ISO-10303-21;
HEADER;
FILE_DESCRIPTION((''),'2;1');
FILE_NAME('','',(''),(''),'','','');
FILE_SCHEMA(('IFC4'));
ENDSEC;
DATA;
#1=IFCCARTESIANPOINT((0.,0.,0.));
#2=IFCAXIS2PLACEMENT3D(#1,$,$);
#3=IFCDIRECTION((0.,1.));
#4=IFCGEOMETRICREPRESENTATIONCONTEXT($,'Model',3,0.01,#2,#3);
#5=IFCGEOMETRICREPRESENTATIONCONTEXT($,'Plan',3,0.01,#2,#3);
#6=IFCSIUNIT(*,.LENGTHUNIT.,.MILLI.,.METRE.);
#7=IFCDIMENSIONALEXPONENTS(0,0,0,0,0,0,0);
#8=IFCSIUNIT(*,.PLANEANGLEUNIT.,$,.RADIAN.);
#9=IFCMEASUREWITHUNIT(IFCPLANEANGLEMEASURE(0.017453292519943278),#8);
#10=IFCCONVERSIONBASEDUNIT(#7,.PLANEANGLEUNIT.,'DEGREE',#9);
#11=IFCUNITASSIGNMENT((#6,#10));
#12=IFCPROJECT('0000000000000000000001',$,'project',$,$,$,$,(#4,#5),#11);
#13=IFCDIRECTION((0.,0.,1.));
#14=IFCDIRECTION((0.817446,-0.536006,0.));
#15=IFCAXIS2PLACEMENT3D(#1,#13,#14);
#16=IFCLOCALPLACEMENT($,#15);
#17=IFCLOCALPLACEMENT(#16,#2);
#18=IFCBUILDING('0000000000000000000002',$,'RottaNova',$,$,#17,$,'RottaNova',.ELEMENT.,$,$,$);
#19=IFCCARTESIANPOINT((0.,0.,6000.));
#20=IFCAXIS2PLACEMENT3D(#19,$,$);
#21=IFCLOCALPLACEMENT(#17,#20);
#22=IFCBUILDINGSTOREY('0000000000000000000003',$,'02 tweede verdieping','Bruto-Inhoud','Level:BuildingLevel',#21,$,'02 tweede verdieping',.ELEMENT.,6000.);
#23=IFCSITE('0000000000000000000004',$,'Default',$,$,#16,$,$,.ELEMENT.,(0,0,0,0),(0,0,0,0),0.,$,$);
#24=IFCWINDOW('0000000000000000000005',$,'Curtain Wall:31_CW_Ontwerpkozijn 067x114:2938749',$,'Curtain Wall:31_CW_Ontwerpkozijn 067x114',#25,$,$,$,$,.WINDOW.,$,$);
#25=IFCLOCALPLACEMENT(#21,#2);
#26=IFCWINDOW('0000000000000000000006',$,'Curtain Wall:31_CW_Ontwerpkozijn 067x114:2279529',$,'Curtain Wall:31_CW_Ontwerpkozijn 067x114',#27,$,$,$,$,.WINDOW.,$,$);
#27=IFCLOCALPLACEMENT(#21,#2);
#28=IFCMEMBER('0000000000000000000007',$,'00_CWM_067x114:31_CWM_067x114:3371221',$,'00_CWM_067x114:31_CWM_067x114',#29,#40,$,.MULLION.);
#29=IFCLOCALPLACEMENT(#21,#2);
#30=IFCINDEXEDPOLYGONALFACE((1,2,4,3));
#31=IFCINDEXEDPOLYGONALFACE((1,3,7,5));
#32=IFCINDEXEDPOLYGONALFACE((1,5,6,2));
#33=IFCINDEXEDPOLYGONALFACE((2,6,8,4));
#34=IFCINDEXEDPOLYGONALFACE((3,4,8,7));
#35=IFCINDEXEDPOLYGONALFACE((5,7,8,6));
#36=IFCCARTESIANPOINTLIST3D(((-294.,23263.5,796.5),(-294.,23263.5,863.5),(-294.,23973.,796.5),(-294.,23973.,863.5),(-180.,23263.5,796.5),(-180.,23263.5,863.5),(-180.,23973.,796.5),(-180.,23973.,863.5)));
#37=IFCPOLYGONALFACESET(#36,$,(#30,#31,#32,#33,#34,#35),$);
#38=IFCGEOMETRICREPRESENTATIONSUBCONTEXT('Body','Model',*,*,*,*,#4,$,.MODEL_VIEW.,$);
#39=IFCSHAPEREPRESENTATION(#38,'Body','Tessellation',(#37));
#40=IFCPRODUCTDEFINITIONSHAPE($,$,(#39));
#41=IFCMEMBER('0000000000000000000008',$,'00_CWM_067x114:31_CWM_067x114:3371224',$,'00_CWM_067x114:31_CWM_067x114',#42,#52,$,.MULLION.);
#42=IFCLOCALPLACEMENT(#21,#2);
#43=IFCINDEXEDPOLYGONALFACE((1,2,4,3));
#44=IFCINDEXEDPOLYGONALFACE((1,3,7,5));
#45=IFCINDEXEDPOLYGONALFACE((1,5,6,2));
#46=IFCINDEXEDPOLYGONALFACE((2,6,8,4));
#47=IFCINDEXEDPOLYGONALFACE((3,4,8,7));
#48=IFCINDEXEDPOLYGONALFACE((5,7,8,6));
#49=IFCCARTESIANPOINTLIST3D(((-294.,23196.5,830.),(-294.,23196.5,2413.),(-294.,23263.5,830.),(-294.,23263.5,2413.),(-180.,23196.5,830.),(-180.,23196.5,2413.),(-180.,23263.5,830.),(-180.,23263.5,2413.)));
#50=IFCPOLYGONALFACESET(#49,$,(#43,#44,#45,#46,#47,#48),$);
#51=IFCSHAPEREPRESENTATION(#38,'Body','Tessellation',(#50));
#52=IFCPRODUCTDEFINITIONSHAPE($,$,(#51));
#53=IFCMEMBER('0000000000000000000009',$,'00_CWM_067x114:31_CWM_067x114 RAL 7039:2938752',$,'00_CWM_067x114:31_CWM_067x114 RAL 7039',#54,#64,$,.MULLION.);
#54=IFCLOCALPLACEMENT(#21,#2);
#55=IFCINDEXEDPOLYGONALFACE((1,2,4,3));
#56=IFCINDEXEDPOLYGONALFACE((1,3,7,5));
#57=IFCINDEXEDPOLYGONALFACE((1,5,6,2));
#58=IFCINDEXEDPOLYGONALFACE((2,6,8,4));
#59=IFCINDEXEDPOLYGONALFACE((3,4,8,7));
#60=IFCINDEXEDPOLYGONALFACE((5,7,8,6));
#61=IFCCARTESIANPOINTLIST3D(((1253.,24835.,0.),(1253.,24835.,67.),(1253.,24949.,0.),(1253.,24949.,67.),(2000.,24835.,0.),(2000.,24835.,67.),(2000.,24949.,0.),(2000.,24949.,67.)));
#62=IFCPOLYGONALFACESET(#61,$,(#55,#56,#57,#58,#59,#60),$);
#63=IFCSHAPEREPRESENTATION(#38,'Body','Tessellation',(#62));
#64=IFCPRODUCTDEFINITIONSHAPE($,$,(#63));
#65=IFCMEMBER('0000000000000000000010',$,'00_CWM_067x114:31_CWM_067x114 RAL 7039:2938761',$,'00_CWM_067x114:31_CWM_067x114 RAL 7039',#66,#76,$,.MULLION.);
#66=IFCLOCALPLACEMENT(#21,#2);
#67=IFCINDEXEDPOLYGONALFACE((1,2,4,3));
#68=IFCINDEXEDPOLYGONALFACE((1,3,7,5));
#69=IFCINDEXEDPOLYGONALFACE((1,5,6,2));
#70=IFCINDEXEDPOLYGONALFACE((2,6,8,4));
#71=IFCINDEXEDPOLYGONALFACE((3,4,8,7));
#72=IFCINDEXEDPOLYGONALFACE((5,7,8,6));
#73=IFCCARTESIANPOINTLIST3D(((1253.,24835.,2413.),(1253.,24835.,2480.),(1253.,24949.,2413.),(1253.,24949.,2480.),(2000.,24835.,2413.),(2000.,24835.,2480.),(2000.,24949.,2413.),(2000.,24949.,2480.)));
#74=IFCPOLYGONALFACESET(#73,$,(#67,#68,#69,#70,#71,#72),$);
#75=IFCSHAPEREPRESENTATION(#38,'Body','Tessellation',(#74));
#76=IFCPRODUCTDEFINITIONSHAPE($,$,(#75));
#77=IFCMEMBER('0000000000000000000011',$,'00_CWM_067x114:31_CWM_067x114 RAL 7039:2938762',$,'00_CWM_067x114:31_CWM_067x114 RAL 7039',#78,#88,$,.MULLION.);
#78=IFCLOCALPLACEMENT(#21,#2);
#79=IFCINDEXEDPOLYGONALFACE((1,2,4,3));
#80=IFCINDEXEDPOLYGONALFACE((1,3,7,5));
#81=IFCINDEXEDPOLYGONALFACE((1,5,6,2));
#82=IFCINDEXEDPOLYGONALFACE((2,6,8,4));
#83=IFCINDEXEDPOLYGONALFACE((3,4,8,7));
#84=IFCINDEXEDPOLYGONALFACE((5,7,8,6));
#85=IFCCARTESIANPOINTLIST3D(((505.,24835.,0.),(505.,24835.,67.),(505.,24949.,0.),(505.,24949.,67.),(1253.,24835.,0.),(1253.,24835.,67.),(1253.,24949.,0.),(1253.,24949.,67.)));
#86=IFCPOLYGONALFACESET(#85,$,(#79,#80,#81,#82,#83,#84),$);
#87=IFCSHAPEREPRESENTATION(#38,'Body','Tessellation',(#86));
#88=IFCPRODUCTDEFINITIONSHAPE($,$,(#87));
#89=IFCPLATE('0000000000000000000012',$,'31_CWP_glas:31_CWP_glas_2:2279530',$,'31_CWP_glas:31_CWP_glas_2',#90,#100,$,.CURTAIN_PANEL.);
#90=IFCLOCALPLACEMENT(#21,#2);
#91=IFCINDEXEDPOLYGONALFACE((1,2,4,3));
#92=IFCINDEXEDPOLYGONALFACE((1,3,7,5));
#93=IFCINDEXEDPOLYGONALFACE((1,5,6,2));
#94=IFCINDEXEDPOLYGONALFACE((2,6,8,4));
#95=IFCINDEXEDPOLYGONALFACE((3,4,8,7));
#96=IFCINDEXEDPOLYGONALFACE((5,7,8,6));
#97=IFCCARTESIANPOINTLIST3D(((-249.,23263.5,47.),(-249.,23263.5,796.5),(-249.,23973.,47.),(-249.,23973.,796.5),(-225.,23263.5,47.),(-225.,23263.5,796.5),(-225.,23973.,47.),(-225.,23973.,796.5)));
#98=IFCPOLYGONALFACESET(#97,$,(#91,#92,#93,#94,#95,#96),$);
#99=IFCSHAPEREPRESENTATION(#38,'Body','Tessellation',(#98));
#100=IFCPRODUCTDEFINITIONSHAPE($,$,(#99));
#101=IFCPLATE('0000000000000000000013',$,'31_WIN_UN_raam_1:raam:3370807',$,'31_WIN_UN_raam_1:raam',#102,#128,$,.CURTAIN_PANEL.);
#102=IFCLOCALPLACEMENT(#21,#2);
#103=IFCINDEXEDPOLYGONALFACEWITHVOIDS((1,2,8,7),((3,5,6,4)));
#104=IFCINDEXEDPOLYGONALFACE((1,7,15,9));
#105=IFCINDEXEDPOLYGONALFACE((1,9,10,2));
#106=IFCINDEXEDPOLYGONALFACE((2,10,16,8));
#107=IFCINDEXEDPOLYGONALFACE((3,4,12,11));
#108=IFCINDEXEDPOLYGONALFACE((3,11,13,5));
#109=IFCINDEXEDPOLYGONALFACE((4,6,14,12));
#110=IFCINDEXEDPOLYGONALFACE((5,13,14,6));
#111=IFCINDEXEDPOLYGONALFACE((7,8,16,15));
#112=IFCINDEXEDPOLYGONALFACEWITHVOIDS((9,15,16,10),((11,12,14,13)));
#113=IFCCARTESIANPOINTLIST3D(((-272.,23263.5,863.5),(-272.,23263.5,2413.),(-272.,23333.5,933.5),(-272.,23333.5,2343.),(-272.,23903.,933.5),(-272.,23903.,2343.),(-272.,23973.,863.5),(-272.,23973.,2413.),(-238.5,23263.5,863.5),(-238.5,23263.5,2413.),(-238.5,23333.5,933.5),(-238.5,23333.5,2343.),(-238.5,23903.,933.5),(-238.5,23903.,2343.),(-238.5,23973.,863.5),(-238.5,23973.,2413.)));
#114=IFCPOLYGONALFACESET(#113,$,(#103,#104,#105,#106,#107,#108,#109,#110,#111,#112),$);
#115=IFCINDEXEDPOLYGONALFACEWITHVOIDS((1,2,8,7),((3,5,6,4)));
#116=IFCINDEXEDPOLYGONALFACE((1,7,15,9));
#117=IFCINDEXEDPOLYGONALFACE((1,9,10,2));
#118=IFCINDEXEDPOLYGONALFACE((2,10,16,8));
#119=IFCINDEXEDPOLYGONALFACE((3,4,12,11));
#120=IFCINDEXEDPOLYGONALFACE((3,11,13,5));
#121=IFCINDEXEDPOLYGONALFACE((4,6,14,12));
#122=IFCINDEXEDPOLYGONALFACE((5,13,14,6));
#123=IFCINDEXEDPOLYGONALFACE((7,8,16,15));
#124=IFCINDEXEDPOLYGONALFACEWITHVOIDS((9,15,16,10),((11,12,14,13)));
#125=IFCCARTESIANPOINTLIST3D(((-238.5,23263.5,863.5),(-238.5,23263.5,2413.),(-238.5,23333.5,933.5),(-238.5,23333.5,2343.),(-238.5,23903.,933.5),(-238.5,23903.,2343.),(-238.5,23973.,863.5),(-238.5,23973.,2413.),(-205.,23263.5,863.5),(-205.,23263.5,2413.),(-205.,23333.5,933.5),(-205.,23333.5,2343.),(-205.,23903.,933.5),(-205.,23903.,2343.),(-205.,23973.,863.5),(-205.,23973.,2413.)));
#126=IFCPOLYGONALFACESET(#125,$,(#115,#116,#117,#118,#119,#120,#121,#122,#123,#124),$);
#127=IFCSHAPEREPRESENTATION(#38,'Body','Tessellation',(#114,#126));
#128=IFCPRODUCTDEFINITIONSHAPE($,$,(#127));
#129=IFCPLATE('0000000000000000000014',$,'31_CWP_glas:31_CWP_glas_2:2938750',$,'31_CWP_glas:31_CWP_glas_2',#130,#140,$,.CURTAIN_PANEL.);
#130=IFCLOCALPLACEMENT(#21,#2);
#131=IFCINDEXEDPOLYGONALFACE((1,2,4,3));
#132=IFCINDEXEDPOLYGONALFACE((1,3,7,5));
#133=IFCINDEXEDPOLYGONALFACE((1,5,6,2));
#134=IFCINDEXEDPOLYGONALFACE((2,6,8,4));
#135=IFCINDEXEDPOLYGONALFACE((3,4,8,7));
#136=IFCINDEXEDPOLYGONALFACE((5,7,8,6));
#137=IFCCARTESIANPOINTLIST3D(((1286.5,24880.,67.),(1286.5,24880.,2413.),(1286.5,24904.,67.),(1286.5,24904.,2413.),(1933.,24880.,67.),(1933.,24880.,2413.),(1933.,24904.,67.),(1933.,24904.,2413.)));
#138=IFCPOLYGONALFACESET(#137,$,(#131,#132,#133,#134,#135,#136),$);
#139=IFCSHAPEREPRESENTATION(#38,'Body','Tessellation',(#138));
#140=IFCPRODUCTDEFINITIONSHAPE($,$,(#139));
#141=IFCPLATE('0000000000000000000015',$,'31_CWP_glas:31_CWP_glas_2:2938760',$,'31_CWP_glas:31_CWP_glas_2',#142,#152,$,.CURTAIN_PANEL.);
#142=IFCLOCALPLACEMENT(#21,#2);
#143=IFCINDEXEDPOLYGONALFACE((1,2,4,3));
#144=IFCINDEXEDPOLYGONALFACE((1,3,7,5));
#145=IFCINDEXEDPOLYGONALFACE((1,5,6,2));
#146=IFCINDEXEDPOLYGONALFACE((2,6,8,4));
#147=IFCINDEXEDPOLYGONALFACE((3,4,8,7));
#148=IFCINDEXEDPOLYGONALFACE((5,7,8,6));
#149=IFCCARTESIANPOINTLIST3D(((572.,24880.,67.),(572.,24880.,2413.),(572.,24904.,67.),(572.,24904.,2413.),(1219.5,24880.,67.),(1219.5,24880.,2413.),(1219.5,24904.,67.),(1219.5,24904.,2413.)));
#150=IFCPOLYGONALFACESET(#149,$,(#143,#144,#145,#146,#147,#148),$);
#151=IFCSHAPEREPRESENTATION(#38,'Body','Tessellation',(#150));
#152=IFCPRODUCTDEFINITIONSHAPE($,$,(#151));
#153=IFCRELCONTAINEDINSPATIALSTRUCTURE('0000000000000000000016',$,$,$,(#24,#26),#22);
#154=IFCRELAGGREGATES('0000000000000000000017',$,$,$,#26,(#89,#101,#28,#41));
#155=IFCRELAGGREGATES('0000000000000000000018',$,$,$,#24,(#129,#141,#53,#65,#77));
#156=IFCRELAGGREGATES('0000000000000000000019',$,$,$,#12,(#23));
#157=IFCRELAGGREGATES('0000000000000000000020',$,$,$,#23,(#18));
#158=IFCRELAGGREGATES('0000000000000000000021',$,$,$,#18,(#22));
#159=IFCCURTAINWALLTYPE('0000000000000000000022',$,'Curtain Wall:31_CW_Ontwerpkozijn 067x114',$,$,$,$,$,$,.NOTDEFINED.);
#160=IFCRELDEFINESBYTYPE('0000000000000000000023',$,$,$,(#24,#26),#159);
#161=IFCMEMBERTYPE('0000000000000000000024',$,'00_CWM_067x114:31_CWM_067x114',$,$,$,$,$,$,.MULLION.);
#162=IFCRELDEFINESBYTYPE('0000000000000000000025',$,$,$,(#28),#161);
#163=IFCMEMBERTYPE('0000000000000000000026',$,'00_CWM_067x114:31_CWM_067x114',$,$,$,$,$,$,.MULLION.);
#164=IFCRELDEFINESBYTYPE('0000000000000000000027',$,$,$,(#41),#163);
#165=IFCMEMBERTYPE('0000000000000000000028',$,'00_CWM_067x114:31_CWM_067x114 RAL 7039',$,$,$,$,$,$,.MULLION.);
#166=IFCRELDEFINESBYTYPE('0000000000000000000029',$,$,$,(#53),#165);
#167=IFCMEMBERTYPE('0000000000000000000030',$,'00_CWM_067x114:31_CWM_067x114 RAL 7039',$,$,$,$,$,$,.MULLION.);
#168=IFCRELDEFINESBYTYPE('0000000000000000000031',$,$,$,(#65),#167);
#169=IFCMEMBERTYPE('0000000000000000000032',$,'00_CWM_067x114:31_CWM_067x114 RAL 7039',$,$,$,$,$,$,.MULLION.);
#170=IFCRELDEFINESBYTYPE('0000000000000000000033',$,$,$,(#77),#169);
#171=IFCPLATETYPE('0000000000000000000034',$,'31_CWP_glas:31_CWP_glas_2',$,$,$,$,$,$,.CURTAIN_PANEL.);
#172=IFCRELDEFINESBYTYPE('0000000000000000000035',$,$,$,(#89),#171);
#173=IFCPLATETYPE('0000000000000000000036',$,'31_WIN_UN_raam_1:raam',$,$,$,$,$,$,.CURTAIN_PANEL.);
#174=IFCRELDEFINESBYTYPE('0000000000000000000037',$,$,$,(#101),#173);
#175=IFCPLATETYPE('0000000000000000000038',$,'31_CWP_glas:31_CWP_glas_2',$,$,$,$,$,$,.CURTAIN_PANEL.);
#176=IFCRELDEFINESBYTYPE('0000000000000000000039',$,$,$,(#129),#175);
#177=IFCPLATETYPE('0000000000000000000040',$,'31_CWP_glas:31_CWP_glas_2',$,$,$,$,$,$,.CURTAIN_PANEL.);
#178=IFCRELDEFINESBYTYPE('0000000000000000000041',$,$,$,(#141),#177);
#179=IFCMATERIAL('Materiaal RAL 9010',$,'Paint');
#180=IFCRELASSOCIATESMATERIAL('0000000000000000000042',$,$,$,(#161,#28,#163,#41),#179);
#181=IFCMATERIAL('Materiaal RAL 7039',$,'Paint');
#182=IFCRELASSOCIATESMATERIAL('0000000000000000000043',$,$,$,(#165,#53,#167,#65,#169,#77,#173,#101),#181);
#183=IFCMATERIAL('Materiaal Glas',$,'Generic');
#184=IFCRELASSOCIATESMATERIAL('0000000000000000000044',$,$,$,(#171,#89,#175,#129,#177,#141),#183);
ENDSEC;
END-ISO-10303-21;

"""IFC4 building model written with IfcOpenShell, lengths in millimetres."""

from ifc_helpers import new_model, entity, si_unit, converted_unit, direction, frame, origin, place, context, subcontext, project, spatial, indexed_curve, outline, extrude, source, transform, mapped, material, type_object, type_shapes, element, aggregate, save


model = new_model("IFC4")

# Units and contexts
model_context = context("Model", 3, precision=0.01, world=origin(), true_north=direction((0.0, 1.0)))
plan_context = context("Plan", 3, precision=0.01, world=origin(), true_north=direction((0.0, 1.0)))
body_context = subcontext(model_context, "Body", "Model", "MODEL_VIEW")
ifc_project = project(units=[si_unit("LENGTHUNIT", "METRE", prefix="MILLI"), converted_unit("PLANEANGLEUNIT", "DEGREE", entity("IfcPlaneAngleMeasure", 0.017453292519943278), si_unit("PLANEANGLEUNIT", "RADIAN"), dimensions=[0, 0, 0, 0, 0, 0, 0])], contexts=[model_context, plan_context])

# Site, building, storey
site_placement = place(None, frame((0.0, 0.0, 0.0), z_axis=(0.0, 0.0, 1.0), x_axis=(0.817446, -0.536006, 0.0)))
site = spatial("IfcSite", under=ifc_project, at=site_placement, Name="Default", CompositionType="ELEMENT", RefLatitude=(0, 0, 0, 0), RefLongitude=(0, 0, 0, 0), RefElevation=0.0)
building_placement = place(site_placement, origin())
building = spatial("IfcBuilding", under=site, at=building_placement, Name="RottaNova", LongName="RottaNova", CompositionType="ELEMENT")
storey_placement = place(building_placement, frame((0.0, 0.0, 6000.0)))
storey = spatial("IfcBuildingStorey", under=building, at=storey_placement, Name="02 tweede verdieping", Description="Bruto-Inhoud", ObjectType="Level:BuildingLevel", LongName="02 tweede verdieping", CompositionType="ELEMENT", Elevation=6000.0)

# Window
curtain_wall_type = type_object("IfcCurtainWallType", Name="Curtain Wall:31_CW_Ontwerpkozijn 067x114", PredefinedType="NOTDEFINED")
ifc_material_1 = material(Name="Materiaal RAL 7039", Category="Paint")
window_1_placement = place(storey_placement, frame((0.0, 0.0, -6000.0)))
window_1 = element("IfcWindow", 1, at=window_1_placement, inside=storey, type_object=curtain_wall_type, Name="Curtain Wall:31_CW_Ontwerpkozijn 067x114:2938749", ObjectType="Curtain Wall:31_CW_Ontwerpkozijn 067x114", PredefinedType="WINDOW")

# Window, members
window_2_placement = place(storey_placement, frame((0.0, 0.0, -6000.0)))
window_2 = element("IfcWindow", 2, at=window_2_placement, inside=storey, type_object=curtain_wall_type, Name="Curtain Wall:31_CW_Ontwerpkozijn 067x114:2279529", ObjectType="Curtain Wall:31_CW_Ontwerpkozijn 067x114", PredefinedType="WINDOW")
ifc_material_2 = material(Name="Materiaal RAL 9010", Category="Paint")
member_type_1 = type_object("IfcMemberType", Name="00_CWM_067x114:31_CWM_067x114", PredefinedType="MULLION", material=ifc_material_2)
shared_shape_1 = source(origin(), body_context, "Body", "SweptSolid", [
    extrude(outline(indexed_curve([(-33.5, -57.0), (33.5, -57.0), (33.5, 57.0), (-33.5, 57.0), (-33.5, -57.0)], self_intersect=False)), frame((0.0, 57.0, -709.5), z_axis=(0.0, 0.0, 1.0), x_axis=(-1.0, 0.0, 0.0)), (0.0, 0.0, 1.0), 709.5),
])
type_shapes(member_type_1, [shared_shape_1])
member_1_placement = place(window_2_placement, frame((-180.0, 23263.5, 6830.0), z_axis=(0.0, -1.0, 0.0), x_axis=(0.0, 0.0, 1.0)))
member_1 = element("IfcMember", 3, at=member_1_placement, type_object=member_type_1, material=ifc_material_2, Name="00_CWM_067x114:31_CWM_067x114:3371221", ObjectType="00_CWM_067x114:31_CWM_067x114", PredefinedType="MULLION", context=body_context, shape_type="MappedRepresentation", body=[
    mapped(shared_shape_1, transform((0.0, 0.0, 0.0), scale=1.0)),
])
member_type_2 = type_object("IfcMemberType", Name="00_CWM_067x114:31_CWM_067x114", PredefinedType="MULLION", material=ifc_material_2)
shared_shape_2 = source(origin(), body_context, "Body", "SweptSolid", [
    extrude(outline(indexed_curve([(-33.5, -57.0), (33.5, -57.0), (33.5, 57.0), (-33.5, 57.0), (-33.5, -57.0)], self_intersect=False)), frame((0.0, 57.0, -1583.0), z_axis=(0.0, 0.0, 1.0), x_axis=(-1.0, 0.0, 0.0)), (0.0, 0.0, 1.0), 1583.0),
])
type_shapes(member_type_2, [shared_shape_2])
member_2_placement = place(window_2_placement, frame((-180.0, 23230.0, 6830.0), z_axis=(0.0, 0.0, -1.0), x_axis=(0.0, -1.0, 0.0)))
member_2 = element("IfcMember", 4, at=member_2_placement, type_object=member_type_2, material=ifc_material_2, Name="00_CWM_067x114:31_CWM_067x114:3371224", ObjectType="00_CWM_067x114:31_CWM_067x114", PredefinedType="MULLION", context=body_context, shape_type="MappedRepresentation", body=[
    mapped(shared_shape_2, transform((0.0, 0.0, 0.0), scale=1.0)),
])

# Members
member_type_3 = type_object("IfcMemberType", Name="00_CWM_067x114:31_CWM_067x114 RAL 7039", PredefinedType="MULLION", material=ifc_material_1)
shared_shape_3 = source(origin(), body_context, "Body", "SweptSolid", [
    extrude(outline(indexed_curve([(-33.5, -57.0), (33.5, -57.0), (33.5, 57.0), (-33.5, 57.0), (-33.5, -57.0)], self_intersect=False)), frame((-33.5, 57.0, -747.0), z_axis=(0.0, 0.0, 1.0), x_axis=(-1.0, 0.0, 0.0)), (0.0, 0.0, 1.0), 747.0),
])
type_shapes(member_type_3, [shared_shape_3])
member_3_placement = place(window_1_placement, frame((2000.0, 24835.0, 6000.0), z_axis=(1.0, 0.0, 0.0), x_axis=(0.0, 0.0, -1.0)))
member_3 = element("IfcMember", 5, at=member_3_placement, type_object=member_type_3, material=ifc_material_1, Name="00_CWM_067x114:31_CWM_067x114 RAL 7039:2938752", ObjectType="00_CWM_067x114:31_CWM_067x114 RAL 7039", PredefinedType="MULLION", context=body_context, shape_type="MappedRepresentation", body=[
    mapped(shared_shape_3, transform((0.0, 0.0, 0.0), scale=1.0)),
])
member_type_4 = type_object("IfcMemberType", Name="00_CWM_067x114:31_CWM_067x114 RAL 7039", PredefinedType="MULLION", material=ifc_material_1)
shared_shape_4 = source(origin(), body_context, "Body", "SweptSolid", [
    extrude(outline(indexed_curve([(-33.5, -57.0), (33.5, -57.0), (33.5, 57.0), (-33.5, 57.0), (-33.5, -57.0)], self_intersect=False)), frame((-33.5, 57.0, -747.0), z_axis=(0.0, 0.0, 1.0), x_axis=(-1.0, 0.0, 0.0)), (0.0, 0.0, 1.0), 747.0),
])
type_shapes(member_type_4, [shared_shape_4])
member_4_placement = place(window_1_placement, frame((1253.0, 24835.0, 8480.0), z_axis=(-1.0, 0.0, 0.0), x_axis=(0.0, 0.0, 1.0)))
member_4 = element("IfcMember", 6, at=member_4_placement, type_object=member_type_4, material=ifc_material_1, Name="00_CWM_067x114:31_CWM_067x114 RAL 7039:2938761", ObjectType="00_CWM_067x114:31_CWM_067x114 RAL 7039", PredefinedType="MULLION", context=body_context, shape_type="MappedRepresentation", body=[
    mapped(shared_shape_4, transform((0.0, 0.0, 0.0), scale=1.0)),
])
member_type_5 = type_object("IfcMemberType", Name="00_CWM_067x114:31_CWM_067x114 RAL 7039", PredefinedType="MULLION", material=ifc_material_1)
shared_shape_5 = source(origin(), body_context, "Body", "SweptSolid", [
    extrude(outline(indexed_curve([(-33.5, -57.0), (33.5, -57.0), (33.5, 57.0), (-33.5, 57.0), (-33.5, -57.0)], self_intersect=False)), frame((-33.5, 57.0, -748.0), z_axis=(0.0, 0.0, 1.0), x_axis=(-1.0, 0.0, 0.0)), (0.0, 0.0, 1.0), 748.0),
])
type_shapes(member_type_5, [shared_shape_5])
member_5_placement = place(window_1_placement, frame((1253.0, 24835.0, 6000.0), z_axis=(1.0, 0.0, 0.0), x_axis=(0.0, 0.0, -1.0)))
member_5 = element("IfcMember", 7, at=member_5_placement, type_object=member_type_5, material=ifc_material_1, Name="00_CWM_067x114:31_CWM_067x114 RAL 7039:2938762", ObjectType="00_CWM_067x114:31_CWM_067x114 RAL 7039", PredefinedType="MULLION", context=body_context, shape_type="MappedRepresentation", body=[
    mapped(shared_shape_5, transform((0.0, 0.0, 0.0), scale=1.0)),
])

# Plates
ifc_material_3 = material(Name="Materiaal Glas", Category="Generic")
plate_type_1 = type_object("IfcPlateType", Name="31_CWP_glas:31_CWP_glas_2", PredefinedType="CURTAIN_PANEL", material=ifc_material_3)
shared_shape_6 = source(origin(), body_context, "Body", "SweptSolid", [
    extrude(outline(indexed_curve([(-12.0, -354.8), (12.0, -354.8), (12.0, 354.8), (-12.0, 354.8), (-12.0, -354.8)], self_intersect=False)), frame((0.0, -57.0, 0.0), z_axis=(0.0, 0.0, 1.0), x_axis=(0.0, 1.0, 0.0)), (0.0, 0.0, 1.0), 749.5),
])
type_shapes(plate_type_1, [shared_shape_6])
plate_1_placement = place(window_2_placement, frame((-180.0, 23618.2, 6047.0), z_axis=(0.0, 0.0, 1.0), x_axis=(0.0, -1.0, 0.0)))
plate_1 = element("IfcPlate", 8, at=plate_1_placement, type_object=plate_type_1, material=ifc_material_3, Name="31_CWP_glas:31_CWP_glas_2:2279530", ObjectType="31_CWP_glas:31_CWP_glas_2", PredefinedType="CURTAIN_PANEL", context=body_context, shape_type="MappedRepresentation", body=[
    mapped(shared_shape_6, transform((0.0, 0.0, 0.0), scale=1.0)),
])
plate_type_2 = type_object("IfcPlateType", Name="31_WIN_UN_raam_1:raam", PredefinedType="CURTAIN_PANEL", material=ifc_material_1)
shared_shape_7 = source(origin(), body_context, "Body", "SweptSolid", [
    extrude(outline(indexed_curve([(-354.7, -774.7), (354.7, -774.7), (354.7, 774.7), (-354.7, 774.7), (-354.7, -774.7)], self_intersect=False), holes=[indexed_curve([(-284.7, 704.7), (284.7, 704.7), (284.7, -704.8), (-284.7, -704.8), (-284.7, 704.7)], self_intersect=False)]), frame((0.0, -92.0, 774.8), z_axis=(0.0, 1.0, 0.0), x_axis=(1.0, 0.0, 0.0)), (0.0, 0.0, 1.0), 33.5),
    extrude(outline(indexed_curve([(-354.7, -774.7), (354.7, -774.7), (354.7, 774.7), (-354.7, 774.7), (-354.7, -774.7)], self_intersect=False), holes=[indexed_curve([(-284.7, 704.7), (284.7, 704.7), (284.7, -704.8), (-284.7, -704.8), (-284.7, 704.7)], self_intersect=False)]), frame((0.0, -58.5, 774.8), z_axis=(0.0, 1.0, 0.0), x_axis=(1.0, 0.0, 0.0)), (0.0, 0.0, 1.0), 33.5),
])
type_shapes(plate_type_2, [shared_shape_7])
plate_2_placement = place(window_2_placement, frame((-180.0, 23618.2, 6863.5), z_axis=(0.0, 0.0, 1.0), x_axis=(0.0, -1.0, 0.0)))
plate_2 = element("IfcPlate", 9, at=plate_2_placement, type_object=plate_type_2, material=ifc_material_1, Name="31_WIN_UN_raam_1:raam:3370807", ObjectType="31_WIN_UN_raam_1:raam", PredefinedType="CURTAIN_PANEL", context=body_context, shape_type="MappedRepresentation", body=[
    mapped(shared_shape_7, transform((0.0, 0.0, 0.0), scale=1.0)),
])
aggregate(window_2, [plate_1, plate_2, member_1, member_2])
plate_type_3 = type_object("IfcPlateType", Name="31_CWP_glas:31_CWP_glas_2", PredefinedType="CURTAIN_PANEL", material=ifc_material_3)
shared_shape_8 = source(origin(), body_context, "Body", "SweptSolid", [
    extrude(outline(indexed_curve([(-12.0, -323.2), (12.0, -323.2), (12.0, 323.2), (-12.0, 323.2), (-12.0, -323.2)], self_intersect=False)), frame((0.0, -57.0, 0.0), z_axis=(0.0, 0.0, 1.0), x_axis=(0.0, 1.0, 0.0)), (0.0, 0.0, 1.0), 2346.0),
])
type_shapes(plate_type_3, [shared_shape_8])
plate_3_placement = place(window_1_placement, frame((1609.8, 24835.0, 6067.0), z_axis=(0.0, 0.0, 1.0), x_axis=(-1.0, 0.0, 0.0)))
plate_3 = element("IfcPlate", 10, at=plate_3_placement, type_object=plate_type_3, material=ifc_material_3, Name="31_CWP_glas:31_CWP_glas_2:2938750", ObjectType="31_CWP_glas:31_CWP_glas_2", PredefinedType="CURTAIN_PANEL", context=body_context, shape_type="MappedRepresentation", body=[
    mapped(shared_shape_8, transform((0.0, 0.0, 0.0), scale=1.0)),
])
plate_type_4 = type_object("IfcPlateType", Name="31_CWP_glas:31_CWP_glas_2", PredefinedType="CURTAIN_PANEL", material=ifc_material_3)
shared_shape_9 = source(origin(), body_context, "Body", "SweptSolid", [
    extrude(outline(indexed_curve([(-12.0, -323.7), (12.0, -323.7), (12.0, 323.7), (-12.0, 323.7), (-12.0, -323.7)], self_intersect=False)), frame((0.0, -57.0, 0.0), z_axis=(0.0, 0.0, 1.0), x_axis=(0.0, 1.0, 0.0)), (0.0, 0.0, 1.0), 2346.0),
])
type_shapes(plate_type_4, [shared_shape_9])
plate_4_placement = place(window_1_placement, frame((895.8, 24835.0, 6067.0), z_axis=(0.0, 0.0, 1.0), x_axis=(-1.0, 0.0, 0.0)))
plate_4 = element("IfcPlate", 11, at=plate_4_placement, type_object=plate_type_4, material=ifc_material_3, Name="31_CWP_glas:31_CWP_glas_2:2938760", ObjectType="31_CWP_glas:31_CWP_glas_2", PredefinedType="CURTAIN_PANEL", context=body_context, shape_type="MappedRepresentation", body=[
    mapped(shared_shape_9, transform((0.0, 0.0, 0.0), scale=1.0)),
])
aggregate(window_1, [plate_3, plate_4, member_3, member_4, member_5])

save(model, "model.ifc")
